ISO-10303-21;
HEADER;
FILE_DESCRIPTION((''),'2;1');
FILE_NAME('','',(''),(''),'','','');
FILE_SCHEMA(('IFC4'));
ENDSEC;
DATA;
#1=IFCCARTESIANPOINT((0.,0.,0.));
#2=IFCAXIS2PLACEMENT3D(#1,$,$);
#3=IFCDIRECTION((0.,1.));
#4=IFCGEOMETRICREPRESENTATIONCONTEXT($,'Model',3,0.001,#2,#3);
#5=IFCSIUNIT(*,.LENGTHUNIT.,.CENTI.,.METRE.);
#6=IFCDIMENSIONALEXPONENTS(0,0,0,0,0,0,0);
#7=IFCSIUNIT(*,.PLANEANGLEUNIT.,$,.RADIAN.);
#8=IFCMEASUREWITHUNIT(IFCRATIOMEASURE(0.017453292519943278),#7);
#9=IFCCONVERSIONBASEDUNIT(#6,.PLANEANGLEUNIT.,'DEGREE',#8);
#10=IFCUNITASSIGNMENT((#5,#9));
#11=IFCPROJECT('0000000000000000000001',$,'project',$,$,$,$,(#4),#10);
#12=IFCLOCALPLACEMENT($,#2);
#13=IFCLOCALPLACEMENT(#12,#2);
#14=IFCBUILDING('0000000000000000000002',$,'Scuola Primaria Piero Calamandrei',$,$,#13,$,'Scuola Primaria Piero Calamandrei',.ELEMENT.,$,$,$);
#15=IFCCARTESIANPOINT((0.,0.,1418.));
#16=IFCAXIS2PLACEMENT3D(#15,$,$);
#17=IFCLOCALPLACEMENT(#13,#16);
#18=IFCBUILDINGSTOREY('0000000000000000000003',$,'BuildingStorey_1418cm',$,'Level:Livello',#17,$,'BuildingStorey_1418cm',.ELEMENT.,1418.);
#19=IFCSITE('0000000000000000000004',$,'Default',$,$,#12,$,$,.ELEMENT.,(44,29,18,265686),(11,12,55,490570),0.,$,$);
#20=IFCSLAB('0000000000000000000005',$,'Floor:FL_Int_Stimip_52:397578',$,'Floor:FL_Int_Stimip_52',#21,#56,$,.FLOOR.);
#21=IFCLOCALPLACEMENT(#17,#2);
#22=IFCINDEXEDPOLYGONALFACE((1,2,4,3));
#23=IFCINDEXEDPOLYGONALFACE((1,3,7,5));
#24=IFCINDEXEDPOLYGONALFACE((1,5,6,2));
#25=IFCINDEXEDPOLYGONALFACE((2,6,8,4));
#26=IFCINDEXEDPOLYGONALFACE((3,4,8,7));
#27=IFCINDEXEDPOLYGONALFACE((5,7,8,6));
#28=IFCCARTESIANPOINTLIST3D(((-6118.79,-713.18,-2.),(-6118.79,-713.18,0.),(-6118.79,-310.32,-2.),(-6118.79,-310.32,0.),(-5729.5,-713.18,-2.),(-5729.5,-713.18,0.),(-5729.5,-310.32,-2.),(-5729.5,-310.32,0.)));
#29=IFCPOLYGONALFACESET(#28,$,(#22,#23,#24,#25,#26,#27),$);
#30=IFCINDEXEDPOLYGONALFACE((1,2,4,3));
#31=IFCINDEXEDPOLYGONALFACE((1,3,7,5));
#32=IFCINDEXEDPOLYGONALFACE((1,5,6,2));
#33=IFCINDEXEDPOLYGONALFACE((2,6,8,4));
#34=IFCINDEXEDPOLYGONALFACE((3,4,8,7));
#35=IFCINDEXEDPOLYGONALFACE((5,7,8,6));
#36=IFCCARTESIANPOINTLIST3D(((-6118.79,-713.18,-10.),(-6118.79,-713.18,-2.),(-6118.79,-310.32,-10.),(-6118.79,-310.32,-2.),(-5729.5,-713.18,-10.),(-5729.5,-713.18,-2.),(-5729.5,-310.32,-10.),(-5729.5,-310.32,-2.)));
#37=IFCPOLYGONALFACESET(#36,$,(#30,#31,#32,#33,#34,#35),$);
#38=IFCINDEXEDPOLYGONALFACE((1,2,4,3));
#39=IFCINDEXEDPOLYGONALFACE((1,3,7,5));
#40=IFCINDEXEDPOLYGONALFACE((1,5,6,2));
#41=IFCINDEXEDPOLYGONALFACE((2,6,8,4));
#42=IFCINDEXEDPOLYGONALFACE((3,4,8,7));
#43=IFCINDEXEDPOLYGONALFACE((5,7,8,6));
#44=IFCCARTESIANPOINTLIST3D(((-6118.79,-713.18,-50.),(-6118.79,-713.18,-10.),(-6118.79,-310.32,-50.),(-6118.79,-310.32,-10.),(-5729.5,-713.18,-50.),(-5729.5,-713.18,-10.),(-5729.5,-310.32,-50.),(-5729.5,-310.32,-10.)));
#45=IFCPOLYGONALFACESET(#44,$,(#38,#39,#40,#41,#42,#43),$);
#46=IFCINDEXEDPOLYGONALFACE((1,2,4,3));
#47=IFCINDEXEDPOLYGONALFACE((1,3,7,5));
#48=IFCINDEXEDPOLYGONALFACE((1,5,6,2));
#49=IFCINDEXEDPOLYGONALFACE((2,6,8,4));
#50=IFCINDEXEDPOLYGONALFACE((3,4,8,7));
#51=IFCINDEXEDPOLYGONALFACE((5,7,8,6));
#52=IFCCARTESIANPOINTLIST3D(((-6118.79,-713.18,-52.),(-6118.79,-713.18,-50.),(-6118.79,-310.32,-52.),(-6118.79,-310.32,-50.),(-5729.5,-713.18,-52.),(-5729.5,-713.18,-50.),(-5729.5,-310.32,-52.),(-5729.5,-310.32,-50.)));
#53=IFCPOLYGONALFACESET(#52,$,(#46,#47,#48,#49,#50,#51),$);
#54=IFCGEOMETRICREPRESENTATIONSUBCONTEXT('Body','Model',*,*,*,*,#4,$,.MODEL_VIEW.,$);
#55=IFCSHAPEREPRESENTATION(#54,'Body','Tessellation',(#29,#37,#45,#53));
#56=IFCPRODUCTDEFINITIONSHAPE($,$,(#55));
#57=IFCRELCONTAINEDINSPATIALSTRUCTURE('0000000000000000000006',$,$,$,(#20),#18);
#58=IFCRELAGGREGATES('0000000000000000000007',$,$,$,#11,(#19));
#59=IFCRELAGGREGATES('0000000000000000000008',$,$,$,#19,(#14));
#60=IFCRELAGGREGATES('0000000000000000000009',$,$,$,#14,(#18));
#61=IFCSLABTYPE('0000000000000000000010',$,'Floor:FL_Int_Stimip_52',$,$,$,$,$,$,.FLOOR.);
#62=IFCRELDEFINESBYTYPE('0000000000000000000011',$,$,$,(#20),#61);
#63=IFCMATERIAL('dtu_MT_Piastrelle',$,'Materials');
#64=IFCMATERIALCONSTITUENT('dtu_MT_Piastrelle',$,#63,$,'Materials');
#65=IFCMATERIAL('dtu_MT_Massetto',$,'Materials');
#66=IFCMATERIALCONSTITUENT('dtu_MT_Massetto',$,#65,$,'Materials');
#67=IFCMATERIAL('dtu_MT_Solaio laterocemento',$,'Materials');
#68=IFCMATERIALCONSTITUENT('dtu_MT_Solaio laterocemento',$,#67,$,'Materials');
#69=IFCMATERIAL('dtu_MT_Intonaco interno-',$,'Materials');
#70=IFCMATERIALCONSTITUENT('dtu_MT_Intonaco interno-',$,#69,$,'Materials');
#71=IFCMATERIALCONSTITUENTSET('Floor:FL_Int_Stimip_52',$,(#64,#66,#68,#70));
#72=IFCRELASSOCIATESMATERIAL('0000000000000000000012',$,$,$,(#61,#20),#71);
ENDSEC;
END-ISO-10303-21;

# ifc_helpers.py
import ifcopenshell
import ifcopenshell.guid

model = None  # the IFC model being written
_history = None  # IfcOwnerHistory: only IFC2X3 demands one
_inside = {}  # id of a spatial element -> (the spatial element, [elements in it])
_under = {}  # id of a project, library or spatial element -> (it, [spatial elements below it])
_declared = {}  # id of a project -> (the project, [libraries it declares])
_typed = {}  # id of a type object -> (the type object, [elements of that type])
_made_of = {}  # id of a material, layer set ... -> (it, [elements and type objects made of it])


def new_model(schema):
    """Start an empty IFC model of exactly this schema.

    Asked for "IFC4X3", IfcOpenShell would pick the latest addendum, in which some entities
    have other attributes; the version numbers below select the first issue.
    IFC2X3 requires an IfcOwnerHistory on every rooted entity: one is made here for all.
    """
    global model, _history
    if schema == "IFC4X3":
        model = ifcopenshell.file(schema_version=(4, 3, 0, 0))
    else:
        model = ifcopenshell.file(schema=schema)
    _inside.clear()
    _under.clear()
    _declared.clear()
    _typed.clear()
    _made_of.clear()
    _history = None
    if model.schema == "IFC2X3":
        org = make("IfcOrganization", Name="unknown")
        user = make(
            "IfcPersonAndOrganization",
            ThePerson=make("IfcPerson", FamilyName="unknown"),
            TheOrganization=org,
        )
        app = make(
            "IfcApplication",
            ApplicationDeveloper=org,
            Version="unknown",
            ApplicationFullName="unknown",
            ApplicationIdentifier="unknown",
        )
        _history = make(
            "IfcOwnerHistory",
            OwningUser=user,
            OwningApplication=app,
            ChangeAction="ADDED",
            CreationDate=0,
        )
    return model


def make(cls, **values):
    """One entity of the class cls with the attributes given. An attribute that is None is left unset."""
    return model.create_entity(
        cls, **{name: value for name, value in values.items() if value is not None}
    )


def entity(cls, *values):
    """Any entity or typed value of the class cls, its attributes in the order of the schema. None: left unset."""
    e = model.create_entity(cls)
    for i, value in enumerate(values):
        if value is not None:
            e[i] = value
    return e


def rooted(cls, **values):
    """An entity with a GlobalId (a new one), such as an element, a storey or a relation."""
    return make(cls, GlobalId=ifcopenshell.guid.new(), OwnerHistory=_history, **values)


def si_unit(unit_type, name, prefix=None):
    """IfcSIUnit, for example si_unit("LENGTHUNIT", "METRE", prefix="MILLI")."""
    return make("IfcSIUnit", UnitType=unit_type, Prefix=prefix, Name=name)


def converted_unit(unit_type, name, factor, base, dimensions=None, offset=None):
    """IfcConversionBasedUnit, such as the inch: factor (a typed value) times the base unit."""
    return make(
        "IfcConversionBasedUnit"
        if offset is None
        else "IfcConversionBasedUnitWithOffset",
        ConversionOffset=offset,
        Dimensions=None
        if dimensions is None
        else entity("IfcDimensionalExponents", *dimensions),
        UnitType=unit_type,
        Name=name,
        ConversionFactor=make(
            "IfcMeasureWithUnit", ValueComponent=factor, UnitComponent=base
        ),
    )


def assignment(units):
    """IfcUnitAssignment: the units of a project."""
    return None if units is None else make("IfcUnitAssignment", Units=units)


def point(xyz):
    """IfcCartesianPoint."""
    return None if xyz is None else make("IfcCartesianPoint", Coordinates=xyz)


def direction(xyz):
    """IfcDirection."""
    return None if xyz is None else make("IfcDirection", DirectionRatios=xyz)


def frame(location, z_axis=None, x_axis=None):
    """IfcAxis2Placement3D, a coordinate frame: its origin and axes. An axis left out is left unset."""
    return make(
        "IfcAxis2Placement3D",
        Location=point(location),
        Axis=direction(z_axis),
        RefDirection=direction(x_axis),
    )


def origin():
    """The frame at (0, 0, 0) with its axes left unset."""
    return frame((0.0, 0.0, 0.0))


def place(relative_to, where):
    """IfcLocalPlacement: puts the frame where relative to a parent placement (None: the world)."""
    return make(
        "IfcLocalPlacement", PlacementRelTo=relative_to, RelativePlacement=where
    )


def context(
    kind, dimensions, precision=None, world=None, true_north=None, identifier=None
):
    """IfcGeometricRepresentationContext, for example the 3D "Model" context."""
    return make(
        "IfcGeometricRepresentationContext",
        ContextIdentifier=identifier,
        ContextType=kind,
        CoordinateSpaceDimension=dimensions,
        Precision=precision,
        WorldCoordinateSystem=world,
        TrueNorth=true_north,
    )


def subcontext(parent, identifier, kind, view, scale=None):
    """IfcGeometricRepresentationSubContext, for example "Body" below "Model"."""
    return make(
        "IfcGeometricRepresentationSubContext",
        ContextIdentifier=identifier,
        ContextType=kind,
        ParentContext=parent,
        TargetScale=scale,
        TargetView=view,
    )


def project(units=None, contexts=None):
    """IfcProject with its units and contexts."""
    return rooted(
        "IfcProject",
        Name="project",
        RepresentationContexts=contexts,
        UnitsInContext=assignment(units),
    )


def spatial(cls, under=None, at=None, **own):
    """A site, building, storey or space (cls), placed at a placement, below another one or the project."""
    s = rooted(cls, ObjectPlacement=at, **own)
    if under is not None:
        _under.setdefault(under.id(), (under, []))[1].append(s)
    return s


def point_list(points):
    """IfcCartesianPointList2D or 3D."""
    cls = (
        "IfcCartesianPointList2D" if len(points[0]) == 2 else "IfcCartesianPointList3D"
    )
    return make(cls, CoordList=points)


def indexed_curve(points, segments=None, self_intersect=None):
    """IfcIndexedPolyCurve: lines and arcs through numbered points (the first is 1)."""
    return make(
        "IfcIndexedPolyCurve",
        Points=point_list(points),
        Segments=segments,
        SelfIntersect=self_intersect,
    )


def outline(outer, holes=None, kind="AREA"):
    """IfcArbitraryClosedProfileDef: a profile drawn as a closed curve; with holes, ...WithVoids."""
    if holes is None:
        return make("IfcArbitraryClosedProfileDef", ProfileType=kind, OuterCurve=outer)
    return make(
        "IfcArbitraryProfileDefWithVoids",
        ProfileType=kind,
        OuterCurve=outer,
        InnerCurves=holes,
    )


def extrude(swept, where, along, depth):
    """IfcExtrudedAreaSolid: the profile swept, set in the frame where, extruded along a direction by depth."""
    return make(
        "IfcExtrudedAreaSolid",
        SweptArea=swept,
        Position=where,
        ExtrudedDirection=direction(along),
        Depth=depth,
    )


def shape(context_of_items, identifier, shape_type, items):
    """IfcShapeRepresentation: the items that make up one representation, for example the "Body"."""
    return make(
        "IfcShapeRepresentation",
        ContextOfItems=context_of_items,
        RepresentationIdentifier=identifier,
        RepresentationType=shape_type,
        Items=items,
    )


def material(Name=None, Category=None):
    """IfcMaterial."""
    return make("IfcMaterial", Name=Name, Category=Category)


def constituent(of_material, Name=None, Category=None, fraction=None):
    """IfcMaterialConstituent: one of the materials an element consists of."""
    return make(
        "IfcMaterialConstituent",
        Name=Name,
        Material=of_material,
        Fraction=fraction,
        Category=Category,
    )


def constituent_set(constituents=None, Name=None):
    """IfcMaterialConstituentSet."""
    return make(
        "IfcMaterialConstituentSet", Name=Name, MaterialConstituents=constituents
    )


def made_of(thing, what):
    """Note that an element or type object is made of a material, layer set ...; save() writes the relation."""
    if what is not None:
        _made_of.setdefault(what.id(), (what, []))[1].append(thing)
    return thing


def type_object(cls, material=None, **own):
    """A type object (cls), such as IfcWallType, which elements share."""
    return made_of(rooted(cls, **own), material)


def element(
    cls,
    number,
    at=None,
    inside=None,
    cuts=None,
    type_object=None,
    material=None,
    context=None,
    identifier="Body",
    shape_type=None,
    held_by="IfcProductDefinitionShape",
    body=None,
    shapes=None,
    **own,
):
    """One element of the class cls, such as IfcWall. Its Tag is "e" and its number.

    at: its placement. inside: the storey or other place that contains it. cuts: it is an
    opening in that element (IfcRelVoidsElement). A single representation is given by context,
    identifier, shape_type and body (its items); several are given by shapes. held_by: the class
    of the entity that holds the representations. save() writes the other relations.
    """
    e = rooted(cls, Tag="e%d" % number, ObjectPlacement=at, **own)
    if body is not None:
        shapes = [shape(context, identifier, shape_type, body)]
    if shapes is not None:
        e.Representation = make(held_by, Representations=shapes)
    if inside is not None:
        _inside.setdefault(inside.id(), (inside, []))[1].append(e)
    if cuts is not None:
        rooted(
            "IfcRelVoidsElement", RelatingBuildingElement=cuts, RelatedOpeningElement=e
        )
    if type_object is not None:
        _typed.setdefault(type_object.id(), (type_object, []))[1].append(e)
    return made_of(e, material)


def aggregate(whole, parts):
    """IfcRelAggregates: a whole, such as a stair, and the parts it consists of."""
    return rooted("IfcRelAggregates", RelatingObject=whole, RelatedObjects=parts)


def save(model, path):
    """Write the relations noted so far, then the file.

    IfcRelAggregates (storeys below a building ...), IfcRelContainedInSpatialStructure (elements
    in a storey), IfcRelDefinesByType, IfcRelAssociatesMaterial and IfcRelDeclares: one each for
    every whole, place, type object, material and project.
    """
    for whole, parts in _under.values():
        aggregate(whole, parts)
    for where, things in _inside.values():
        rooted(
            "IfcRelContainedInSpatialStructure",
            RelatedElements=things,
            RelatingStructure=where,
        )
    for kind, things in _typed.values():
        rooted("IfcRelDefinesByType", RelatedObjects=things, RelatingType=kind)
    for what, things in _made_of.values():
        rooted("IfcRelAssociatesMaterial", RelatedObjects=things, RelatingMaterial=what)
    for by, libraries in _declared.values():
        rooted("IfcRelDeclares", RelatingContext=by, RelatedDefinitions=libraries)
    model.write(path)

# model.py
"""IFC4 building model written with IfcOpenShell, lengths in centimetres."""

from ifc_helpers import new_model, entity, si_unit, converted_unit, direction, frame, origin, place, context, subcontext, project, spatial, indexed_curve, outline, extrude, material, constituent, constituent_set, type_object, element, save


model = new_model("IFC4")

# Units and contexts
model_context = context("Model", 3, precision=0.001, world=origin(), true_north=direction((0.0, 1.0)))
body_context = subcontext(model_context, "Body", "Model", "MODEL_VIEW")
ifc_project = project(units=[si_unit("LENGTHUNIT", "METRE", prefix="CENTI"), converted_unit("PLANEANGLEUNIT", "DEGREE", entity("IfcRatioMeasure", 0.017453292519943278), si_unit("PLANEANGLEUNIT", "RADIAN"), dimensions=[0, 0, 0, 0, 0, 0, 0])], contexts=[model_context])

# Site, building, storey
site_placement = place(None, origin())
site = spatial("IfcSite", under=ifc_project, at=site_placement, Name="Default", CompositionType="ELEMENT", RefLatitude=(44, 29, 18, 265686), RefLongitude=(11, 12, 55, 490570), RefElevation=0.0)
building_placement = place(site_placement, origin())
building = spatial("IfcBuilding", under=site, at=building_placement, Name="Scuola Primaria Piero Calamandrei", LongName="Scuola Primaria Piero Calamandrei", CompositionType="ELEMENT")
storey_placement = place(building_placement, frame((0.0, 0.0, 1418.0)))
storey = spatial("IfcBuildingStorey", under=building, at=storey_placement, Name="BuildingStorey_1418cm", ObjectType="Level:Livello", LongName="BuildingStorey_1418cm", CompositionType="ELEMENT", Elevation=1418.0)

# Slab
ifc_material_1 = material(Name="dtu_MT_Piastrelle", Category="Materials")
ifc_constituent_1 = constituent(ifc_material_1, Name="dtu_MT_Piastrelle", Category="Materials")
ifc_material_2 = material(Name="dtu_MT_Massetto", Category="Materials")
ifc_constituent_2 = constituent(ifc_material_2, Name="dtu_MT_Massetto", Category="Materials")
ifc_material_3 = material(Name="dtu_MT_Solaio laterocemento", Category="Materials")
ifc_constituent_3 = constituent(ifc_material_3, Name="dtu_MT_Solaio laterocemento", Category="Materials")
ifc_material_4 = material(Name="dtu_MT_Intonaco interno-", Category="Materials")
ifc_constituent_4 = constituent(ifc_material_4, Name="dtu_MT_Intonaco interno-", Category="Materials")
ifc_constituent_set = constituent_set(constituents=[ifc_constituent_1, ifc_constituent_2, ifc_constituent_3, ifc_constituent_4], Name="Floor:FL_Int_Stimip_52")
slab_type_1 = type_object("IfcSlabType", Name="Floor:FL_Int_Stimip_52", PredefinedType="FLOOR", material=ifc_constituent_set)
slab_1_placement = place(storey_placement, origin())
element("IfcSlab", 1, at=slab_1_placement, inside=storey, type_object=slab_type_1, material=ifc_constituent_set, Name="Floor:FL_Int_Stimip_52:397578", ObjectType="Floor:FL_Int_Stimip_52", PredefinedType="FLOOR", context=body_context, shape_type="SweptSolid", body=[
    extrude(outline(indexed_curve([(-194.65, -201.43), (194.65, -201.43), (194.65, 201.43), (-194.65, 201.43), (-194.65, -201.43)], self_intersect=False)), frame((-5924.15, -511.75, -2.0)), (0.0, 0.0, 1.0), 2.0),
    extrude(outline(indexed_curve([(-194.65, -201.43), (194.65, -201.43), (194.65, 201.43), (-194.65, 201.43), (-194.65, -201.43)], self_intersect=False)), frame((-5924.15, -511.75, -10.0)), (0.0, 0.0, 1.0), 8.0),
    extrude(outline(indexed_curve([(-194.65, -201.43), (194.65, -201.43), (194.65, 201.43), (-194.65, 201.43), (-194.65, -201.43)], self_intersect=False)), frame((-5924.15, -511.75, -50.0)), (0.0, 0.0, 1.0), 40.0),
    extrude(outline(indexed_curve([(-194.65, -201.43), (194.65, -201.43), (194.65, 201.43), (-194.65, 201.43), (-194.65, -201.43)], self_intersect=False)), frame((-5924.15, -511.75, -52.0)), (0.0, 0.0, 1.0), 2.0),
])

save(model, "model.ifc")
